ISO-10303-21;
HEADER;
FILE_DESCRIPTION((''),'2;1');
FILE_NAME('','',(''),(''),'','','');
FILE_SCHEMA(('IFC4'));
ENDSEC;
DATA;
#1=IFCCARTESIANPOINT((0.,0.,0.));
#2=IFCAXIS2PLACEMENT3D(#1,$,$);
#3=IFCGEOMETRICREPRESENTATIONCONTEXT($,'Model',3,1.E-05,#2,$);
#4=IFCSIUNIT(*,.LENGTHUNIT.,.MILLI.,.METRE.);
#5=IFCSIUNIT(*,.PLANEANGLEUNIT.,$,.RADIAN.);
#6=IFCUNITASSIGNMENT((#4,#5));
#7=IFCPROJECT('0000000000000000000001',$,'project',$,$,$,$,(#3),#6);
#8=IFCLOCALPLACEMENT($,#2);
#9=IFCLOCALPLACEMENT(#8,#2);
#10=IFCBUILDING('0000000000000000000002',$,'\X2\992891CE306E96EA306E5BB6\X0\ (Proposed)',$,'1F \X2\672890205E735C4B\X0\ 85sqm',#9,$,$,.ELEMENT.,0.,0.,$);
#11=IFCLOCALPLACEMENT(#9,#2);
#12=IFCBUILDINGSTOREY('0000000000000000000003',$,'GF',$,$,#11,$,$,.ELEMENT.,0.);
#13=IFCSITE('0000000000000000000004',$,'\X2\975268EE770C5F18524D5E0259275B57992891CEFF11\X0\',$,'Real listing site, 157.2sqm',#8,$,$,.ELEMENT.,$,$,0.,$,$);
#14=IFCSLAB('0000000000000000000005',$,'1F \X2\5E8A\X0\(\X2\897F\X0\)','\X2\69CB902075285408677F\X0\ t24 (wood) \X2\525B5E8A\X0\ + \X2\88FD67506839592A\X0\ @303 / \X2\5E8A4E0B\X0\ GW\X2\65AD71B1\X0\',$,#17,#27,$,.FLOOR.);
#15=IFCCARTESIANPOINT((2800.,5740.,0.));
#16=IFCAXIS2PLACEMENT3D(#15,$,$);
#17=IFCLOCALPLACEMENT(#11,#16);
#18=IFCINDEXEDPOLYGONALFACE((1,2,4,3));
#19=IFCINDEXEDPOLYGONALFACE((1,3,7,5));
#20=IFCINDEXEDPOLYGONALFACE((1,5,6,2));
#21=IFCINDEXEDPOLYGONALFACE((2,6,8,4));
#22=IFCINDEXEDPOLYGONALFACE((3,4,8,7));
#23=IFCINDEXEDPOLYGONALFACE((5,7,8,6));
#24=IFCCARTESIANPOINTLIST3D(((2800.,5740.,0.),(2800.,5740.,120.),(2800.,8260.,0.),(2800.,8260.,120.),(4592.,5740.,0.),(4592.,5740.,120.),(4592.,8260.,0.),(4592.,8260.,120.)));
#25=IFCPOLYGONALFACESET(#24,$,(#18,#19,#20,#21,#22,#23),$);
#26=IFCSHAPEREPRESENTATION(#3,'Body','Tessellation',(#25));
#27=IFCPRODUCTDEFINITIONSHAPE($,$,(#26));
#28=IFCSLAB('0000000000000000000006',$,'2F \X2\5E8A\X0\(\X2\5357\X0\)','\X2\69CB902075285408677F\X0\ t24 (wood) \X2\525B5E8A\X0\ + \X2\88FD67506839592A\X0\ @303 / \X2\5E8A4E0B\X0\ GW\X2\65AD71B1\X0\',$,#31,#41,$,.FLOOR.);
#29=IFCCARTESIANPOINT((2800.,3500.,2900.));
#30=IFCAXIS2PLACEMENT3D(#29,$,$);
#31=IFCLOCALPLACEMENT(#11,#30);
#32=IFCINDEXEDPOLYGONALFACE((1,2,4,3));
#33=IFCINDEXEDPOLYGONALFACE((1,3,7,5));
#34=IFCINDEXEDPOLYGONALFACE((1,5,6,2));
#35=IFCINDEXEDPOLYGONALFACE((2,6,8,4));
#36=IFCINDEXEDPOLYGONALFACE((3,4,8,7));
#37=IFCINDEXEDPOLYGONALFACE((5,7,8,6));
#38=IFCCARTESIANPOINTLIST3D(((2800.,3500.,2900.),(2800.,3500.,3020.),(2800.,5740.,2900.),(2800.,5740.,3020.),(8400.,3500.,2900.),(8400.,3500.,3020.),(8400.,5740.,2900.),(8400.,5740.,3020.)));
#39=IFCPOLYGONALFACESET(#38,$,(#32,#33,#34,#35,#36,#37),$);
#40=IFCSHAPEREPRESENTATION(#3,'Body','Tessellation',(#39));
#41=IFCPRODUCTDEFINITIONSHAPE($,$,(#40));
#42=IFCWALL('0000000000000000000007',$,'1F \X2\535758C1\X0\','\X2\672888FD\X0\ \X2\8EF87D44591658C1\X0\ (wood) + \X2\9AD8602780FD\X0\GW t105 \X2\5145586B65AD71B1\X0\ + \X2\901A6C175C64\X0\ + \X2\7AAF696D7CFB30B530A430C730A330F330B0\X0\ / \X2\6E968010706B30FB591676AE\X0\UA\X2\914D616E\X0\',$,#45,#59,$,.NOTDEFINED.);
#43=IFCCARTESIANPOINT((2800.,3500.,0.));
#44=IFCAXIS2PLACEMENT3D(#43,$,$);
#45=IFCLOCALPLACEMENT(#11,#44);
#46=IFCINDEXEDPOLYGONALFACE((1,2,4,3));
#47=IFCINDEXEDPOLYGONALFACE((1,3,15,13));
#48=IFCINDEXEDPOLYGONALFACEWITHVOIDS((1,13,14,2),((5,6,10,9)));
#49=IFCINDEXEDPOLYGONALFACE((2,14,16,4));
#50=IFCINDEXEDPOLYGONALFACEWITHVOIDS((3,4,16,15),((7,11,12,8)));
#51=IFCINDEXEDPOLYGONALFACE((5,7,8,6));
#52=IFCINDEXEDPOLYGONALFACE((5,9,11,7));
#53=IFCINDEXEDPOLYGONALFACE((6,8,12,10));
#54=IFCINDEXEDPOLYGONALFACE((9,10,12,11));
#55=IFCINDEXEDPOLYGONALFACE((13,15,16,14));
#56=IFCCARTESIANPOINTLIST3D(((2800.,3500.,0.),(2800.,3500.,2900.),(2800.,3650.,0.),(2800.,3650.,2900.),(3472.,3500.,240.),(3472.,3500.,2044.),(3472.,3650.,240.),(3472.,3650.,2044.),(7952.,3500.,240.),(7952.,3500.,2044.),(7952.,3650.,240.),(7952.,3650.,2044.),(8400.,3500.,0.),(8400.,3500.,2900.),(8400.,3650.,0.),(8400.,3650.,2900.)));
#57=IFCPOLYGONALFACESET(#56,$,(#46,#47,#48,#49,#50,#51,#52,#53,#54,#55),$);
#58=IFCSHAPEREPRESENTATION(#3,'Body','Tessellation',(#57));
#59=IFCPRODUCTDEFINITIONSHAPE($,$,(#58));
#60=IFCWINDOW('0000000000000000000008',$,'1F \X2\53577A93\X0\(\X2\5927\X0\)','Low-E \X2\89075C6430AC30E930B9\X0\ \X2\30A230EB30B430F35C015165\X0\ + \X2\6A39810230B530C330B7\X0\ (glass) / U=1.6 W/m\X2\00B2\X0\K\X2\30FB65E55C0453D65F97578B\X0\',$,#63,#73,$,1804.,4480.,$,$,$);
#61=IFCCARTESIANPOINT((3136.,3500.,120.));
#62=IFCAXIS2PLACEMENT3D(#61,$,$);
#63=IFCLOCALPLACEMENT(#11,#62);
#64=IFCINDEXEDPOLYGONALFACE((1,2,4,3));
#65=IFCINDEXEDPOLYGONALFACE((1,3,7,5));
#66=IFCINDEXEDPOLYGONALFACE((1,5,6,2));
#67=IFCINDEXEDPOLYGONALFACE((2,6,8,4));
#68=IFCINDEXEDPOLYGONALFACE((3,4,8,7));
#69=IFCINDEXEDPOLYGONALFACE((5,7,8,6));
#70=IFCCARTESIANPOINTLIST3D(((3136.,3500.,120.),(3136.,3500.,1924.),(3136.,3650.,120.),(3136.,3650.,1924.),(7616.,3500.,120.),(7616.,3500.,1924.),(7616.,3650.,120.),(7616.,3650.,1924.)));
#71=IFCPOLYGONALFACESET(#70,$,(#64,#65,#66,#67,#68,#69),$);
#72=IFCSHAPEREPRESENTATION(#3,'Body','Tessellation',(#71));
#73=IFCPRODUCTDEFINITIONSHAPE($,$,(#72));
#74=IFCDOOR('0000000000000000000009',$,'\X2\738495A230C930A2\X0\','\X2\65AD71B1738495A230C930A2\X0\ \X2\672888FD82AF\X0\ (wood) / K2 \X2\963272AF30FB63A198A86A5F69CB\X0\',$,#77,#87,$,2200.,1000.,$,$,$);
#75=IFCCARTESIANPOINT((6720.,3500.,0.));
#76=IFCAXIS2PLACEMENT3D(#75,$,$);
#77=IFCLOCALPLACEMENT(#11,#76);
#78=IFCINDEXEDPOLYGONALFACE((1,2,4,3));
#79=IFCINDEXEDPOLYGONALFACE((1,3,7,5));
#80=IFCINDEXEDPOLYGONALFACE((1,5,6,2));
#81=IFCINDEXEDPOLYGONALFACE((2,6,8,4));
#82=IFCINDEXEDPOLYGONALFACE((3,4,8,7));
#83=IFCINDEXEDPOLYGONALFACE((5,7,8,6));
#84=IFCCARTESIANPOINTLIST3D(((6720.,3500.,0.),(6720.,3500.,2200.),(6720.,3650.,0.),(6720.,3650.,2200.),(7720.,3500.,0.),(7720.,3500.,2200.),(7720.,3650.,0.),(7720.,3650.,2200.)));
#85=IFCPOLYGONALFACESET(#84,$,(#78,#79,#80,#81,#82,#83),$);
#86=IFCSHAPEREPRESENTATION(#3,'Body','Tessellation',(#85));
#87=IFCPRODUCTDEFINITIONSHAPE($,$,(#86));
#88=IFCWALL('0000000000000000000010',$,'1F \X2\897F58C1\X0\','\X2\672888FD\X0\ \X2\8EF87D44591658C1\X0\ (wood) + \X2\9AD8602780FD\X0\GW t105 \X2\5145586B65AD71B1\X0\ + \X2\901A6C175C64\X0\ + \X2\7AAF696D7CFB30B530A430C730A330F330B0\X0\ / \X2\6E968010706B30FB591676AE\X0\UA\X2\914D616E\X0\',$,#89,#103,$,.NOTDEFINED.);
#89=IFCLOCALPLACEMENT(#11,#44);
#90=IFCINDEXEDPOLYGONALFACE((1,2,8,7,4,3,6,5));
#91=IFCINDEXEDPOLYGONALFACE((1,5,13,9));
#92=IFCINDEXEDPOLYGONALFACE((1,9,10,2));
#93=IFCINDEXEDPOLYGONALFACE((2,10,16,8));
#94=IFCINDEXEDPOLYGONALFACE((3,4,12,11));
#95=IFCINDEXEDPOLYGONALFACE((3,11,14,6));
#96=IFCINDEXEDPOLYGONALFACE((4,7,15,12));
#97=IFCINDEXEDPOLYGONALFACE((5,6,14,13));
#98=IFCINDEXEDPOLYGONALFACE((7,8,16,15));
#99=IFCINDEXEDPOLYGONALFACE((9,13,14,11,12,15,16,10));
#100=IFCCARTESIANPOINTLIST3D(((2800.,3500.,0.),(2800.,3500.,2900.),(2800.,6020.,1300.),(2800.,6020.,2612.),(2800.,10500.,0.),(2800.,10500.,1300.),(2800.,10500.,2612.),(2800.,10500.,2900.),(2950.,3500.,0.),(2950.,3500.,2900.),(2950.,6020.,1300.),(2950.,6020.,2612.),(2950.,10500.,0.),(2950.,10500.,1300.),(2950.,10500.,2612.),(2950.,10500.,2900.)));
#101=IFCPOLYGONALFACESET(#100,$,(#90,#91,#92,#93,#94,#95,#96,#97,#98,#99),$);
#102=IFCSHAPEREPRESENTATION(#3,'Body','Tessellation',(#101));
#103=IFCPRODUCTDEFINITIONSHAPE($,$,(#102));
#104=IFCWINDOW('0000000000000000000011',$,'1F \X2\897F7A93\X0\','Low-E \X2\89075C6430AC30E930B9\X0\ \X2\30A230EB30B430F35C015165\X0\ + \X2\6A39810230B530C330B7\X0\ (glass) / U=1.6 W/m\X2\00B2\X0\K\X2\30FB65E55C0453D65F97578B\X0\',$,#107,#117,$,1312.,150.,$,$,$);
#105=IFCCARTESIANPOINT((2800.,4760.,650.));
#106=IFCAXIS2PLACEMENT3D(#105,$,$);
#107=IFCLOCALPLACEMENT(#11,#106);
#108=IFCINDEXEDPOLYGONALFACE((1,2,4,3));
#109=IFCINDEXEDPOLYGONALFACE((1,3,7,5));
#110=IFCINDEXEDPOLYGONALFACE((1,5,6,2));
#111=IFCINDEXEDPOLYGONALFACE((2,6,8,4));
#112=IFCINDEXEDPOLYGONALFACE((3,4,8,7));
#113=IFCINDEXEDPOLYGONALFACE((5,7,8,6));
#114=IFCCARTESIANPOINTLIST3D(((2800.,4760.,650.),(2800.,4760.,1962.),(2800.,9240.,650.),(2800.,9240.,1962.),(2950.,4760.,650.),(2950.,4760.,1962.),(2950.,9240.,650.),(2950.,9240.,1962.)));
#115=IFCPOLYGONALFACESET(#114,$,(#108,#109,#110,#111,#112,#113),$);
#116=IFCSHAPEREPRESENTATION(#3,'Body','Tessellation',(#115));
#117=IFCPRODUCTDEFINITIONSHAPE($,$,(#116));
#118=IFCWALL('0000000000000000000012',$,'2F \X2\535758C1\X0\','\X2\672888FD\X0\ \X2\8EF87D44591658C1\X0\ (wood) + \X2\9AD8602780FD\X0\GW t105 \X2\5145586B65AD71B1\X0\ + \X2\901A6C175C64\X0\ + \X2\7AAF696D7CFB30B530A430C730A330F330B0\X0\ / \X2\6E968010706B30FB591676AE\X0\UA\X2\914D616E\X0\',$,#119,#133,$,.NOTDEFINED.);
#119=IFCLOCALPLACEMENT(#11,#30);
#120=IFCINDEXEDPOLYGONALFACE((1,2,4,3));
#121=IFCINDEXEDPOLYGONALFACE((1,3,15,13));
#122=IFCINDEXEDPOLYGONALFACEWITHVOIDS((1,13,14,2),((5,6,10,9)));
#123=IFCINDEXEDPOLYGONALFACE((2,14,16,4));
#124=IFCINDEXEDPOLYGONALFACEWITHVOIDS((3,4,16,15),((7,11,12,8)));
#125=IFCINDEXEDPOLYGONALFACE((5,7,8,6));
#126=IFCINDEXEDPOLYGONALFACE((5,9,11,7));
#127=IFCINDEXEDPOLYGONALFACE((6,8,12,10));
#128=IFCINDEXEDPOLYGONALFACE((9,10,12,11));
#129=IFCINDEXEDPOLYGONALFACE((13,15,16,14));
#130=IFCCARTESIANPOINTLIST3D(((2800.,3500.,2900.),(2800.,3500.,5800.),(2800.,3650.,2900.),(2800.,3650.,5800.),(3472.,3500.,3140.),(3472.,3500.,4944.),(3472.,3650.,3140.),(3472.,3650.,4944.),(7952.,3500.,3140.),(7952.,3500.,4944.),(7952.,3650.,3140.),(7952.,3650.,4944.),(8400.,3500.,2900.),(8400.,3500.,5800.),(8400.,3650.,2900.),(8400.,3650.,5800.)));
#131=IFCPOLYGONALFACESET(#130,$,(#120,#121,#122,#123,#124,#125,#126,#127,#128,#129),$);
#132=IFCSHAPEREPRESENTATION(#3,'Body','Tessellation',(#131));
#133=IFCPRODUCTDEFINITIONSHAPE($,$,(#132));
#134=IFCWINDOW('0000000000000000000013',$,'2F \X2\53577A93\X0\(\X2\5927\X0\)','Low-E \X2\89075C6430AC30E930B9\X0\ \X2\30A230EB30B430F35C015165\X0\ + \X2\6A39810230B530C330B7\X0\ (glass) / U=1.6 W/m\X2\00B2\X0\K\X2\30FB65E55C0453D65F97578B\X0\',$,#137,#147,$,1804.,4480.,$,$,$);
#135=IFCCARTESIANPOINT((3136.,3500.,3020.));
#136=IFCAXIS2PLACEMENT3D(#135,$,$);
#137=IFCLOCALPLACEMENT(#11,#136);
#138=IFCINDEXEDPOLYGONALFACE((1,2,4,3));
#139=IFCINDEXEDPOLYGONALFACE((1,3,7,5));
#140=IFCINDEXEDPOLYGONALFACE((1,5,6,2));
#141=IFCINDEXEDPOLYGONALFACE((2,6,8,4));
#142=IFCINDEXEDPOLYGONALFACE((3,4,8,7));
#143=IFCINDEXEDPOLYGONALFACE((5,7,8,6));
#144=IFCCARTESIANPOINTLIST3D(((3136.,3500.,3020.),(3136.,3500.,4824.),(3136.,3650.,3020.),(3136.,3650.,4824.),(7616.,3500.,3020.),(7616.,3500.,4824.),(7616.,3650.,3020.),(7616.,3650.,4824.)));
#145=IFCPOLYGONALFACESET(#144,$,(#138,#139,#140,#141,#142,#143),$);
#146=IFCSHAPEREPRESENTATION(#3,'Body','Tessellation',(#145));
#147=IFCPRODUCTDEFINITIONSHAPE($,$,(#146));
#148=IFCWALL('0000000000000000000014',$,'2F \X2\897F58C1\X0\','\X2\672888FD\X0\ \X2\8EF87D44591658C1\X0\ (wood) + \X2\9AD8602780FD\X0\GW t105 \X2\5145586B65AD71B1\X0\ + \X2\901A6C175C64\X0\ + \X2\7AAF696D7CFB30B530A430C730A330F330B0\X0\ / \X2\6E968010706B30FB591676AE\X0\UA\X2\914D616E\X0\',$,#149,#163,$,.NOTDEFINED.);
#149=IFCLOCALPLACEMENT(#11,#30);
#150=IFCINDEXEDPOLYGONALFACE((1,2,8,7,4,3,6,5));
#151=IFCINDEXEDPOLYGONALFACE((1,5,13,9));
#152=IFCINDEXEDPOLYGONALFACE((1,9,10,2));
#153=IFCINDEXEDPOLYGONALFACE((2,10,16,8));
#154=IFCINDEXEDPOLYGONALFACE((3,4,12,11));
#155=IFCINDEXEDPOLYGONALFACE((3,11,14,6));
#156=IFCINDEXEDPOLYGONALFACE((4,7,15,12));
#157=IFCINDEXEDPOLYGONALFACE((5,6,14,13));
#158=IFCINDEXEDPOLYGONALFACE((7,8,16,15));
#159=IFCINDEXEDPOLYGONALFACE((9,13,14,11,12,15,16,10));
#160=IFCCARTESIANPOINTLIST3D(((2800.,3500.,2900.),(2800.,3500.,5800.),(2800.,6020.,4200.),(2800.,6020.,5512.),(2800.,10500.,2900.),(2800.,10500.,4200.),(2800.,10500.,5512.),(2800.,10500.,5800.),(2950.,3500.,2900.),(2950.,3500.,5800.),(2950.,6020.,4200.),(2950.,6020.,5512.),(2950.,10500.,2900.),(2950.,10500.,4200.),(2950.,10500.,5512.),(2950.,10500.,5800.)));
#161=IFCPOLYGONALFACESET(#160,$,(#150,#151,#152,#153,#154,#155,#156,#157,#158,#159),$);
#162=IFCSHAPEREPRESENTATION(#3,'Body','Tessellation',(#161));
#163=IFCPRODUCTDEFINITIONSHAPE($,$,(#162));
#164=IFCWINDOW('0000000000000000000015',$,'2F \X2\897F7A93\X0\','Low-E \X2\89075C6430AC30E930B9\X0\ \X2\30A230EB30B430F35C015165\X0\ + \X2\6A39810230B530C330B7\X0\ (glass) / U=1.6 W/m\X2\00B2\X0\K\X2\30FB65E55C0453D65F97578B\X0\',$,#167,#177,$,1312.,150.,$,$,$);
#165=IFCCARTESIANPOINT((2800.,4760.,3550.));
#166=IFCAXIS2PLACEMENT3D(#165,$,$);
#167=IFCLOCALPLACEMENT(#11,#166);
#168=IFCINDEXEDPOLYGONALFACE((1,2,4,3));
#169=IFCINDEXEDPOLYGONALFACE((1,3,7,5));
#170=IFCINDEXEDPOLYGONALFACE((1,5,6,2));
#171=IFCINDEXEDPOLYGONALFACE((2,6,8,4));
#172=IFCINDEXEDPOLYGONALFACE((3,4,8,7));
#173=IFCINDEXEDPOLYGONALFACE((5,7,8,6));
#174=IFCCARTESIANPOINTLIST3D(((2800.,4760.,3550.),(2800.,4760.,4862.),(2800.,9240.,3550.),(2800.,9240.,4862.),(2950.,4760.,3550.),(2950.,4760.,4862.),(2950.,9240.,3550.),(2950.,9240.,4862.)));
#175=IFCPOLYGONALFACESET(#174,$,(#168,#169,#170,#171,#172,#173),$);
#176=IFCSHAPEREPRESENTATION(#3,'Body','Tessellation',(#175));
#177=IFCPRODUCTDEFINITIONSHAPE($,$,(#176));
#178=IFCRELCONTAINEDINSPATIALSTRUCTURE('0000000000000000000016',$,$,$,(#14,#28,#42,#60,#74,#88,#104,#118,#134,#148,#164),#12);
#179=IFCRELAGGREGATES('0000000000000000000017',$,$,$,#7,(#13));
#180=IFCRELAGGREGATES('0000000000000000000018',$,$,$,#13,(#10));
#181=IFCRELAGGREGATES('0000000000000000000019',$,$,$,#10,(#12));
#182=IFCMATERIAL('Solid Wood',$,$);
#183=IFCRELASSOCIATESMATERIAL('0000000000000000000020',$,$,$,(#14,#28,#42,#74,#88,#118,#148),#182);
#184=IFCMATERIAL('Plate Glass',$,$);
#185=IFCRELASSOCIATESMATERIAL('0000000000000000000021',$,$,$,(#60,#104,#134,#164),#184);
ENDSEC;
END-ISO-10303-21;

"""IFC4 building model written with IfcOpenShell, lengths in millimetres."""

from ifc_helpers import new_model, si_unit, frame, frame_2d, origin, place, context, project, spatial, rectangle, extrude, material, element, fill, save


model = new_model("IFC4")

# Units and contexts
model_context = context("Model", 3, precision=1e-05, world=origin())
ifc_project = project(units=[si_unit("LENGTHUNIT", "METRE", prefix="MILLI"), si_unit("PLANEANGLEUNIT", "RADIAN")], contexts=[model_context])

# Site, building, storey
site_placement = place(None, origin())
site = spatial("IfcSite", under=ifc_project, at=site_placement, Name="青森県弘前市大字館野１", ObjectType="Real listing site, 157.2sqm", CompositionType="ELEMENT", RefElevation=0.0)
building_placement = place(site_placement, origin())
building = spatial("IfcBuilding", under=site, at=building_placement, Name="館野の雪の家 (Proposed)", ObjectType="1F 木造平屋 85sqm", CompositionType="ELEMENT", ElevationOfRefHeight=0.0, ElevationOfTerrain=0.0)
storey_placement = place(building_placement, origin())
storey = spatial("IfcBuildingStorey", under=building, at=storey_placement, Name="GF", CompositionType="ELEMENT", Elevation=0.0)

# Slabs
ifc_material_1 = material(Name="Solid Wood")
slab_1_placement = place(storey_placement, frame((2800.0, 5740.0, 0.0)))
element("IfcSlab", 1, at=slab_1_placement, inside=storey, material=ifc_material_1, Name="1F 床(西)", Description="構造用合板 t24 (wood) 剛床 + 製材根太 @303 / 床下 GW断熱", PredefinedType="FLOOR", context=model_context, shape_type="SweptSolid", body=[
    extrude(rectangle(XDim=1792.0, YDim=2520.0, at=frame_2d((896.0, 1260.0))), frame((2800.0, 5740.0, 0.0)), (0.0, 0.0, 1.0), 120.0),
])
slab_2_placement = place(storey_placement, frame((2800.0, 3500.0, 2900.0)))
element("IfcSlab", 2, at=slab_2_placement, inside=storey, material=ifc_material_1, Name="2F 床(南)", Description="構造用合板 t24 (wood) 剛床 + 製材根太 @303 / 床下 GW断熱", PredefinedType="FLOOR", context=model_context, shape_type="SweptSolid", body=[
    extrude(rectangle(XDim=5600.0, YDim=2240.0, at=frame_2d((2800.0, 1120.0))), frame((2800.0, 3500.0, 2900.0)), (0.0, 0.0, 1.0), 120.0),
])

# Wall, openings, window, door
wall_1_placement = place(storey_placement, frame((2800.0, 3500.0, 0.0)))
wall_1 = element("IfcWall", 3, at=wall_1_placement, inside=storey, material=ifc_material_1, Name="1F 南壁", Description="木製 軸組外壁 (wood) + 高性能GW t105 充填断熱 + 通気層 + 窯業系サイディング / 準耐火・外皮UA配慮", PredefinedType="NOTDEFINED", context=model_context, shape_type="SweptSolid", body=[
    extrude(rectangle(XDim=5600.0, YDim=150.0, at=frame_2d((2800.0, 75.0))), frame((2800.0, 3500.0, 0.0)), (0.0, 0.0, 1.0), 2900.0),
])
opening_1_placement = place(storey_placement, frame((3136.0, 3500.0, 120.0)))
opening_1 = element("IfcOpeningElement", 4, at=opening_1_placement, cuts=wall_1, PredefinedType="NOTDEFINED", context=model_context, shape_type="SweptSolid", body=[
    extrude(rectangle(XDim=4480.0, YDim=150.0, at=frame_2d((2240.0, 75.0))), frame((3136.0, 3500.0, 120.0)), (0.0, 0.0, 1.0), 1804.0),
])
opening_2_placement = place(storey_placement, frame((6720.0, 3500.0, 0.0)))
opening_2 = element("IfcOpeningElement", 5, at=opening_2_placement, cuts=wall_1, PredefinedType="NOTDEFINED", context=model_context, shape_type="SweptSolid", body=[
    extrude(rectangle(XDim=1000.0, YDim=150.0, at=frame_2d((500.0, 75.0))), frame((6720.0, 3500.0, 0.0)), (0.0, 0.0, 1.0), 2200.0),
])
ifc_material_2 = material(Name="Plate Glass")
window_1_placement = place(storey_placement, frame((3136.0, 3500.0, 120.0)))
window_1 = element("IfcWindow", 6, at=window_1_placement, inside=storey, material=ifc_material_2, Name="1F 南窓(大)", Description="Low-E 複層ガラス アルゴン封入 + 樹脂サッシ (glass) / U=1.6 W/m²K・日射取得型", OverallHeight=1804.0, OverallWidth=4480.0, context=model_context, shape_type="SweptSolid", body=[
    extrude(rectangle(XDim=4480.0, YDim=150.0, at=frame_2d((2240.0, 75.0))), frame((3136.0, 3500.0, 120.0)), (0.0, 0.0, 1.0), 1804.0),
])
fill(opening_1, window_1)
door_placement = place(storey_placement, frame((6720.0, 3500.0, 0.0)))
door = element("IfcDoor", 7, at=door_placement, inside=storey, material=ifc_material_1, Name="玄関ドア", Description="断熱玄関ドア 木製芯 (wood) / K2 防犯・採風機構", OverallHeight=2200.0, OverallWidth=1000.0, context=model_context, shape_type="SweptSolid", body=[
    extrude(rectangle(XDim=1000.0, YDim=150.0, at=frame_2d((500.0, 75.0))), frame((6720.0, 3500.0, 0.0)), (0.0, 0.0, 1.0), 2200.0),
])
fill(opening_2, door)

# Walls, openings, windows
wall_2_placement = place(storey_placement, frame((2800.0, 3500.0, 0.0)))
wall_2 = element("IfcWall", 8, at=wall_2_placement, inside=storey, material=ifc_material_1, Name="1F 西壁", Description="木製 軸組外壁 (wood) + 高性能GW t105 充填断熱 + 通気層 + 窯業系サイディング / 準耐火・外皮UA配慮", PredefinedType="NOTDEFINED", context=model_context, shape_type="SweptSolid", body=[
    extrude(rectangle(XDim=150.0, YDim=7000.0, at=frame_2d((75.0, 3500.0))), frame((2800.0, 3500.0, 0.0)), (0.0, 0.0, 1.0), 2900.0),
])
opening_3_placement = place(storey_placement, frame((2800.0, 4760.0, 650.0)))
opening_3 = element("IfcOpeningElement", 9, at=opening_3_placement, cuts=wall_2, PredefinedType="NOTDEFINED", context=model_context, shape_type="SweptSolid", body=[
    extrude(rectangle(XDim=150.0, YDim=4480.0, at=frame_2d((75.0, 2240.0))), frame((2800.0, 4760.0, 650.0)), (0.0, 0.0, 1.0), 1312.0),
])
window_2_placement = place(storey_placement, frame((2800.0, 4760.0, 650.0)))
window_2 = element("IfcWindow", 10, at=window_2_placement, inside=storey, material=ifc_material_2, Name="1F 西窓", Description="Low-E 複層ガラス アルゴン封入 + 樹脂サッシ (glass) / U=1.6 W/m²K・日射取得型", OverallHeight=1312.0, OverallWidth=150.0, context=model_context, shape_type="SweptSolid", body=[
    extrude(rectangle(XDim=150.0, YDim=4480.0, at=frame_2d((75.0, 2240.0))), frame((2800.0, 4760.0, 650.0)), (0.0, 0.0, 1.0), 1312.0),
])
fill(opening_3, window_2)
wall_3_placement = place(storey_placement, frame((2800.0, 3500.0, 2900.0)))
wall_3 = element("IfcWall", 11, at=wall_3_placement, inside=storey, material=ifc_material_1, Name="2F 南壁", Description="木製 軸組外壁 (wood) + 高性能GW t105 充填断熱 + 通気層 + 窯業系サイディング / 準耐火・外皮UA配慮", PredefinedType="NOTDEFINED", context=model_context, shape_type="SweptSolid", body=[
    extrude(rectangle(XDim=5600.0, YDim=150.0, at=frame_2d((2800.0, 75.0))), frame((2800.0, 3500.0, 2900.0)), (0.0, 0.0, 1.0), 2900.0),
])
opening_4_placement = place(storey_placement, frame((3136.0, 3500.0, 3020.0)))
opening_4 = element("IfcOpeningElement", 12, at=opening_4_placement, cuts=wall_3, PredefinedType="NOTDEFINED", context=model_context, shape_type="SweptSolid", body=[
    extrude(rectangle(XDim=4480.0, YDim=150.0, at=frame_2d((2240.0, 75.0))), frame((3136.0, 3500.0, 3020.0)), (0.0, 0.0, 1.0), 1804.0),
])
window_3_placement = place(storey_placement, frame((3136.0, 3500.0, 3020.0)))
window_3 = element("IfcWindow", 13, at=window_3_placement, inside=storey, material=ifc_material_2, Name="2F 南窓(大)", Description="Low-E 複層ガラス アルゴン封入 + 樹脂サッシ (glass) / U=1.6 W/m²K・日射取得型", OverallHeight=1804.0, OverallWidth=4480.0, context=model_context, shape_type="SweptSolid", body=[
    extrude(rectangle(XDim=4480.0, YDim=150.0, at=frame_2d((2240.0, 75.0))), frame((3136.0, 3500.0, 3020.0)), (0.0, 0.0, 1.0), 1804.0),
])
fill(opening_4, window_3)
wall_4_placement = place(storey_placement, frame((2800.0, 3500.0, 2900.0)))
wall_4 = element("IfcWall", 14, at=wall_4_placement, inside=storey, material=ifc_material_1, Name="2F 西壁", Description="木製 軸組外壁 (wood) + 高性能GW t105 充填断熱 + 通気層 + 窯業系サイディング / 準耐火・外皮UA配慮", PredefinedType="NOTDEFINED", context=model_context, shape_type="SweptSolid", body=[
    extrude(rectangle(XDim=150.0, YDim=7000.0, at=frame_2d((75.0, 3500.0))), frame((2800.0, 3500.0, 2900.0)), (0.0, 0.0, 1.0), 2900.0),
])
opening_5_placement = place(storey_placement, frame((2800.0, 4760.0, 3550.0)))
opening_5 = element("IfcOpeningElement", 15, at=opening_5_placement, cuts=wall_4, PredefinedType="NOTDEFINED", context=model_context, shape_type="SweptSolid", body=[
    extrude(rectangle(XDim=150.0, YDim=4480.0, at=frame_2d((75.0, 2240.0))), frame((2800.0, 4760.0, 3550.0)), (0.0, 0.0, 1.0), 1312.0),
])
window_4_placement = place(storey_placement, frame((2800.0, 4760.0, 3550.0)))
window_4 = element("IfcWindow", 16, at=window_4_placement, inside=storey, material=ifc_material_2, Name="2F 西窓", Description="Low-E 複層ガラス アルゴン封入 + 樹脂サッシ (glass) / U=1.6 W/m²K・日射取得型", OverallHeight=1312.0, OverallWidth=150.0, context=model_context, shape_type="SweptSolid", body=[
    extrude(rectangle(XDim=150.0, YDim=4480.0, at=frame_2d((75.0, 2240.0))), frame((2800.0, 4760.0, 3550.0)), (0.0, 0.0, 1.0), 1312.0),
])
fill(opening_5, window_4)

save(model, "model.ifc")
